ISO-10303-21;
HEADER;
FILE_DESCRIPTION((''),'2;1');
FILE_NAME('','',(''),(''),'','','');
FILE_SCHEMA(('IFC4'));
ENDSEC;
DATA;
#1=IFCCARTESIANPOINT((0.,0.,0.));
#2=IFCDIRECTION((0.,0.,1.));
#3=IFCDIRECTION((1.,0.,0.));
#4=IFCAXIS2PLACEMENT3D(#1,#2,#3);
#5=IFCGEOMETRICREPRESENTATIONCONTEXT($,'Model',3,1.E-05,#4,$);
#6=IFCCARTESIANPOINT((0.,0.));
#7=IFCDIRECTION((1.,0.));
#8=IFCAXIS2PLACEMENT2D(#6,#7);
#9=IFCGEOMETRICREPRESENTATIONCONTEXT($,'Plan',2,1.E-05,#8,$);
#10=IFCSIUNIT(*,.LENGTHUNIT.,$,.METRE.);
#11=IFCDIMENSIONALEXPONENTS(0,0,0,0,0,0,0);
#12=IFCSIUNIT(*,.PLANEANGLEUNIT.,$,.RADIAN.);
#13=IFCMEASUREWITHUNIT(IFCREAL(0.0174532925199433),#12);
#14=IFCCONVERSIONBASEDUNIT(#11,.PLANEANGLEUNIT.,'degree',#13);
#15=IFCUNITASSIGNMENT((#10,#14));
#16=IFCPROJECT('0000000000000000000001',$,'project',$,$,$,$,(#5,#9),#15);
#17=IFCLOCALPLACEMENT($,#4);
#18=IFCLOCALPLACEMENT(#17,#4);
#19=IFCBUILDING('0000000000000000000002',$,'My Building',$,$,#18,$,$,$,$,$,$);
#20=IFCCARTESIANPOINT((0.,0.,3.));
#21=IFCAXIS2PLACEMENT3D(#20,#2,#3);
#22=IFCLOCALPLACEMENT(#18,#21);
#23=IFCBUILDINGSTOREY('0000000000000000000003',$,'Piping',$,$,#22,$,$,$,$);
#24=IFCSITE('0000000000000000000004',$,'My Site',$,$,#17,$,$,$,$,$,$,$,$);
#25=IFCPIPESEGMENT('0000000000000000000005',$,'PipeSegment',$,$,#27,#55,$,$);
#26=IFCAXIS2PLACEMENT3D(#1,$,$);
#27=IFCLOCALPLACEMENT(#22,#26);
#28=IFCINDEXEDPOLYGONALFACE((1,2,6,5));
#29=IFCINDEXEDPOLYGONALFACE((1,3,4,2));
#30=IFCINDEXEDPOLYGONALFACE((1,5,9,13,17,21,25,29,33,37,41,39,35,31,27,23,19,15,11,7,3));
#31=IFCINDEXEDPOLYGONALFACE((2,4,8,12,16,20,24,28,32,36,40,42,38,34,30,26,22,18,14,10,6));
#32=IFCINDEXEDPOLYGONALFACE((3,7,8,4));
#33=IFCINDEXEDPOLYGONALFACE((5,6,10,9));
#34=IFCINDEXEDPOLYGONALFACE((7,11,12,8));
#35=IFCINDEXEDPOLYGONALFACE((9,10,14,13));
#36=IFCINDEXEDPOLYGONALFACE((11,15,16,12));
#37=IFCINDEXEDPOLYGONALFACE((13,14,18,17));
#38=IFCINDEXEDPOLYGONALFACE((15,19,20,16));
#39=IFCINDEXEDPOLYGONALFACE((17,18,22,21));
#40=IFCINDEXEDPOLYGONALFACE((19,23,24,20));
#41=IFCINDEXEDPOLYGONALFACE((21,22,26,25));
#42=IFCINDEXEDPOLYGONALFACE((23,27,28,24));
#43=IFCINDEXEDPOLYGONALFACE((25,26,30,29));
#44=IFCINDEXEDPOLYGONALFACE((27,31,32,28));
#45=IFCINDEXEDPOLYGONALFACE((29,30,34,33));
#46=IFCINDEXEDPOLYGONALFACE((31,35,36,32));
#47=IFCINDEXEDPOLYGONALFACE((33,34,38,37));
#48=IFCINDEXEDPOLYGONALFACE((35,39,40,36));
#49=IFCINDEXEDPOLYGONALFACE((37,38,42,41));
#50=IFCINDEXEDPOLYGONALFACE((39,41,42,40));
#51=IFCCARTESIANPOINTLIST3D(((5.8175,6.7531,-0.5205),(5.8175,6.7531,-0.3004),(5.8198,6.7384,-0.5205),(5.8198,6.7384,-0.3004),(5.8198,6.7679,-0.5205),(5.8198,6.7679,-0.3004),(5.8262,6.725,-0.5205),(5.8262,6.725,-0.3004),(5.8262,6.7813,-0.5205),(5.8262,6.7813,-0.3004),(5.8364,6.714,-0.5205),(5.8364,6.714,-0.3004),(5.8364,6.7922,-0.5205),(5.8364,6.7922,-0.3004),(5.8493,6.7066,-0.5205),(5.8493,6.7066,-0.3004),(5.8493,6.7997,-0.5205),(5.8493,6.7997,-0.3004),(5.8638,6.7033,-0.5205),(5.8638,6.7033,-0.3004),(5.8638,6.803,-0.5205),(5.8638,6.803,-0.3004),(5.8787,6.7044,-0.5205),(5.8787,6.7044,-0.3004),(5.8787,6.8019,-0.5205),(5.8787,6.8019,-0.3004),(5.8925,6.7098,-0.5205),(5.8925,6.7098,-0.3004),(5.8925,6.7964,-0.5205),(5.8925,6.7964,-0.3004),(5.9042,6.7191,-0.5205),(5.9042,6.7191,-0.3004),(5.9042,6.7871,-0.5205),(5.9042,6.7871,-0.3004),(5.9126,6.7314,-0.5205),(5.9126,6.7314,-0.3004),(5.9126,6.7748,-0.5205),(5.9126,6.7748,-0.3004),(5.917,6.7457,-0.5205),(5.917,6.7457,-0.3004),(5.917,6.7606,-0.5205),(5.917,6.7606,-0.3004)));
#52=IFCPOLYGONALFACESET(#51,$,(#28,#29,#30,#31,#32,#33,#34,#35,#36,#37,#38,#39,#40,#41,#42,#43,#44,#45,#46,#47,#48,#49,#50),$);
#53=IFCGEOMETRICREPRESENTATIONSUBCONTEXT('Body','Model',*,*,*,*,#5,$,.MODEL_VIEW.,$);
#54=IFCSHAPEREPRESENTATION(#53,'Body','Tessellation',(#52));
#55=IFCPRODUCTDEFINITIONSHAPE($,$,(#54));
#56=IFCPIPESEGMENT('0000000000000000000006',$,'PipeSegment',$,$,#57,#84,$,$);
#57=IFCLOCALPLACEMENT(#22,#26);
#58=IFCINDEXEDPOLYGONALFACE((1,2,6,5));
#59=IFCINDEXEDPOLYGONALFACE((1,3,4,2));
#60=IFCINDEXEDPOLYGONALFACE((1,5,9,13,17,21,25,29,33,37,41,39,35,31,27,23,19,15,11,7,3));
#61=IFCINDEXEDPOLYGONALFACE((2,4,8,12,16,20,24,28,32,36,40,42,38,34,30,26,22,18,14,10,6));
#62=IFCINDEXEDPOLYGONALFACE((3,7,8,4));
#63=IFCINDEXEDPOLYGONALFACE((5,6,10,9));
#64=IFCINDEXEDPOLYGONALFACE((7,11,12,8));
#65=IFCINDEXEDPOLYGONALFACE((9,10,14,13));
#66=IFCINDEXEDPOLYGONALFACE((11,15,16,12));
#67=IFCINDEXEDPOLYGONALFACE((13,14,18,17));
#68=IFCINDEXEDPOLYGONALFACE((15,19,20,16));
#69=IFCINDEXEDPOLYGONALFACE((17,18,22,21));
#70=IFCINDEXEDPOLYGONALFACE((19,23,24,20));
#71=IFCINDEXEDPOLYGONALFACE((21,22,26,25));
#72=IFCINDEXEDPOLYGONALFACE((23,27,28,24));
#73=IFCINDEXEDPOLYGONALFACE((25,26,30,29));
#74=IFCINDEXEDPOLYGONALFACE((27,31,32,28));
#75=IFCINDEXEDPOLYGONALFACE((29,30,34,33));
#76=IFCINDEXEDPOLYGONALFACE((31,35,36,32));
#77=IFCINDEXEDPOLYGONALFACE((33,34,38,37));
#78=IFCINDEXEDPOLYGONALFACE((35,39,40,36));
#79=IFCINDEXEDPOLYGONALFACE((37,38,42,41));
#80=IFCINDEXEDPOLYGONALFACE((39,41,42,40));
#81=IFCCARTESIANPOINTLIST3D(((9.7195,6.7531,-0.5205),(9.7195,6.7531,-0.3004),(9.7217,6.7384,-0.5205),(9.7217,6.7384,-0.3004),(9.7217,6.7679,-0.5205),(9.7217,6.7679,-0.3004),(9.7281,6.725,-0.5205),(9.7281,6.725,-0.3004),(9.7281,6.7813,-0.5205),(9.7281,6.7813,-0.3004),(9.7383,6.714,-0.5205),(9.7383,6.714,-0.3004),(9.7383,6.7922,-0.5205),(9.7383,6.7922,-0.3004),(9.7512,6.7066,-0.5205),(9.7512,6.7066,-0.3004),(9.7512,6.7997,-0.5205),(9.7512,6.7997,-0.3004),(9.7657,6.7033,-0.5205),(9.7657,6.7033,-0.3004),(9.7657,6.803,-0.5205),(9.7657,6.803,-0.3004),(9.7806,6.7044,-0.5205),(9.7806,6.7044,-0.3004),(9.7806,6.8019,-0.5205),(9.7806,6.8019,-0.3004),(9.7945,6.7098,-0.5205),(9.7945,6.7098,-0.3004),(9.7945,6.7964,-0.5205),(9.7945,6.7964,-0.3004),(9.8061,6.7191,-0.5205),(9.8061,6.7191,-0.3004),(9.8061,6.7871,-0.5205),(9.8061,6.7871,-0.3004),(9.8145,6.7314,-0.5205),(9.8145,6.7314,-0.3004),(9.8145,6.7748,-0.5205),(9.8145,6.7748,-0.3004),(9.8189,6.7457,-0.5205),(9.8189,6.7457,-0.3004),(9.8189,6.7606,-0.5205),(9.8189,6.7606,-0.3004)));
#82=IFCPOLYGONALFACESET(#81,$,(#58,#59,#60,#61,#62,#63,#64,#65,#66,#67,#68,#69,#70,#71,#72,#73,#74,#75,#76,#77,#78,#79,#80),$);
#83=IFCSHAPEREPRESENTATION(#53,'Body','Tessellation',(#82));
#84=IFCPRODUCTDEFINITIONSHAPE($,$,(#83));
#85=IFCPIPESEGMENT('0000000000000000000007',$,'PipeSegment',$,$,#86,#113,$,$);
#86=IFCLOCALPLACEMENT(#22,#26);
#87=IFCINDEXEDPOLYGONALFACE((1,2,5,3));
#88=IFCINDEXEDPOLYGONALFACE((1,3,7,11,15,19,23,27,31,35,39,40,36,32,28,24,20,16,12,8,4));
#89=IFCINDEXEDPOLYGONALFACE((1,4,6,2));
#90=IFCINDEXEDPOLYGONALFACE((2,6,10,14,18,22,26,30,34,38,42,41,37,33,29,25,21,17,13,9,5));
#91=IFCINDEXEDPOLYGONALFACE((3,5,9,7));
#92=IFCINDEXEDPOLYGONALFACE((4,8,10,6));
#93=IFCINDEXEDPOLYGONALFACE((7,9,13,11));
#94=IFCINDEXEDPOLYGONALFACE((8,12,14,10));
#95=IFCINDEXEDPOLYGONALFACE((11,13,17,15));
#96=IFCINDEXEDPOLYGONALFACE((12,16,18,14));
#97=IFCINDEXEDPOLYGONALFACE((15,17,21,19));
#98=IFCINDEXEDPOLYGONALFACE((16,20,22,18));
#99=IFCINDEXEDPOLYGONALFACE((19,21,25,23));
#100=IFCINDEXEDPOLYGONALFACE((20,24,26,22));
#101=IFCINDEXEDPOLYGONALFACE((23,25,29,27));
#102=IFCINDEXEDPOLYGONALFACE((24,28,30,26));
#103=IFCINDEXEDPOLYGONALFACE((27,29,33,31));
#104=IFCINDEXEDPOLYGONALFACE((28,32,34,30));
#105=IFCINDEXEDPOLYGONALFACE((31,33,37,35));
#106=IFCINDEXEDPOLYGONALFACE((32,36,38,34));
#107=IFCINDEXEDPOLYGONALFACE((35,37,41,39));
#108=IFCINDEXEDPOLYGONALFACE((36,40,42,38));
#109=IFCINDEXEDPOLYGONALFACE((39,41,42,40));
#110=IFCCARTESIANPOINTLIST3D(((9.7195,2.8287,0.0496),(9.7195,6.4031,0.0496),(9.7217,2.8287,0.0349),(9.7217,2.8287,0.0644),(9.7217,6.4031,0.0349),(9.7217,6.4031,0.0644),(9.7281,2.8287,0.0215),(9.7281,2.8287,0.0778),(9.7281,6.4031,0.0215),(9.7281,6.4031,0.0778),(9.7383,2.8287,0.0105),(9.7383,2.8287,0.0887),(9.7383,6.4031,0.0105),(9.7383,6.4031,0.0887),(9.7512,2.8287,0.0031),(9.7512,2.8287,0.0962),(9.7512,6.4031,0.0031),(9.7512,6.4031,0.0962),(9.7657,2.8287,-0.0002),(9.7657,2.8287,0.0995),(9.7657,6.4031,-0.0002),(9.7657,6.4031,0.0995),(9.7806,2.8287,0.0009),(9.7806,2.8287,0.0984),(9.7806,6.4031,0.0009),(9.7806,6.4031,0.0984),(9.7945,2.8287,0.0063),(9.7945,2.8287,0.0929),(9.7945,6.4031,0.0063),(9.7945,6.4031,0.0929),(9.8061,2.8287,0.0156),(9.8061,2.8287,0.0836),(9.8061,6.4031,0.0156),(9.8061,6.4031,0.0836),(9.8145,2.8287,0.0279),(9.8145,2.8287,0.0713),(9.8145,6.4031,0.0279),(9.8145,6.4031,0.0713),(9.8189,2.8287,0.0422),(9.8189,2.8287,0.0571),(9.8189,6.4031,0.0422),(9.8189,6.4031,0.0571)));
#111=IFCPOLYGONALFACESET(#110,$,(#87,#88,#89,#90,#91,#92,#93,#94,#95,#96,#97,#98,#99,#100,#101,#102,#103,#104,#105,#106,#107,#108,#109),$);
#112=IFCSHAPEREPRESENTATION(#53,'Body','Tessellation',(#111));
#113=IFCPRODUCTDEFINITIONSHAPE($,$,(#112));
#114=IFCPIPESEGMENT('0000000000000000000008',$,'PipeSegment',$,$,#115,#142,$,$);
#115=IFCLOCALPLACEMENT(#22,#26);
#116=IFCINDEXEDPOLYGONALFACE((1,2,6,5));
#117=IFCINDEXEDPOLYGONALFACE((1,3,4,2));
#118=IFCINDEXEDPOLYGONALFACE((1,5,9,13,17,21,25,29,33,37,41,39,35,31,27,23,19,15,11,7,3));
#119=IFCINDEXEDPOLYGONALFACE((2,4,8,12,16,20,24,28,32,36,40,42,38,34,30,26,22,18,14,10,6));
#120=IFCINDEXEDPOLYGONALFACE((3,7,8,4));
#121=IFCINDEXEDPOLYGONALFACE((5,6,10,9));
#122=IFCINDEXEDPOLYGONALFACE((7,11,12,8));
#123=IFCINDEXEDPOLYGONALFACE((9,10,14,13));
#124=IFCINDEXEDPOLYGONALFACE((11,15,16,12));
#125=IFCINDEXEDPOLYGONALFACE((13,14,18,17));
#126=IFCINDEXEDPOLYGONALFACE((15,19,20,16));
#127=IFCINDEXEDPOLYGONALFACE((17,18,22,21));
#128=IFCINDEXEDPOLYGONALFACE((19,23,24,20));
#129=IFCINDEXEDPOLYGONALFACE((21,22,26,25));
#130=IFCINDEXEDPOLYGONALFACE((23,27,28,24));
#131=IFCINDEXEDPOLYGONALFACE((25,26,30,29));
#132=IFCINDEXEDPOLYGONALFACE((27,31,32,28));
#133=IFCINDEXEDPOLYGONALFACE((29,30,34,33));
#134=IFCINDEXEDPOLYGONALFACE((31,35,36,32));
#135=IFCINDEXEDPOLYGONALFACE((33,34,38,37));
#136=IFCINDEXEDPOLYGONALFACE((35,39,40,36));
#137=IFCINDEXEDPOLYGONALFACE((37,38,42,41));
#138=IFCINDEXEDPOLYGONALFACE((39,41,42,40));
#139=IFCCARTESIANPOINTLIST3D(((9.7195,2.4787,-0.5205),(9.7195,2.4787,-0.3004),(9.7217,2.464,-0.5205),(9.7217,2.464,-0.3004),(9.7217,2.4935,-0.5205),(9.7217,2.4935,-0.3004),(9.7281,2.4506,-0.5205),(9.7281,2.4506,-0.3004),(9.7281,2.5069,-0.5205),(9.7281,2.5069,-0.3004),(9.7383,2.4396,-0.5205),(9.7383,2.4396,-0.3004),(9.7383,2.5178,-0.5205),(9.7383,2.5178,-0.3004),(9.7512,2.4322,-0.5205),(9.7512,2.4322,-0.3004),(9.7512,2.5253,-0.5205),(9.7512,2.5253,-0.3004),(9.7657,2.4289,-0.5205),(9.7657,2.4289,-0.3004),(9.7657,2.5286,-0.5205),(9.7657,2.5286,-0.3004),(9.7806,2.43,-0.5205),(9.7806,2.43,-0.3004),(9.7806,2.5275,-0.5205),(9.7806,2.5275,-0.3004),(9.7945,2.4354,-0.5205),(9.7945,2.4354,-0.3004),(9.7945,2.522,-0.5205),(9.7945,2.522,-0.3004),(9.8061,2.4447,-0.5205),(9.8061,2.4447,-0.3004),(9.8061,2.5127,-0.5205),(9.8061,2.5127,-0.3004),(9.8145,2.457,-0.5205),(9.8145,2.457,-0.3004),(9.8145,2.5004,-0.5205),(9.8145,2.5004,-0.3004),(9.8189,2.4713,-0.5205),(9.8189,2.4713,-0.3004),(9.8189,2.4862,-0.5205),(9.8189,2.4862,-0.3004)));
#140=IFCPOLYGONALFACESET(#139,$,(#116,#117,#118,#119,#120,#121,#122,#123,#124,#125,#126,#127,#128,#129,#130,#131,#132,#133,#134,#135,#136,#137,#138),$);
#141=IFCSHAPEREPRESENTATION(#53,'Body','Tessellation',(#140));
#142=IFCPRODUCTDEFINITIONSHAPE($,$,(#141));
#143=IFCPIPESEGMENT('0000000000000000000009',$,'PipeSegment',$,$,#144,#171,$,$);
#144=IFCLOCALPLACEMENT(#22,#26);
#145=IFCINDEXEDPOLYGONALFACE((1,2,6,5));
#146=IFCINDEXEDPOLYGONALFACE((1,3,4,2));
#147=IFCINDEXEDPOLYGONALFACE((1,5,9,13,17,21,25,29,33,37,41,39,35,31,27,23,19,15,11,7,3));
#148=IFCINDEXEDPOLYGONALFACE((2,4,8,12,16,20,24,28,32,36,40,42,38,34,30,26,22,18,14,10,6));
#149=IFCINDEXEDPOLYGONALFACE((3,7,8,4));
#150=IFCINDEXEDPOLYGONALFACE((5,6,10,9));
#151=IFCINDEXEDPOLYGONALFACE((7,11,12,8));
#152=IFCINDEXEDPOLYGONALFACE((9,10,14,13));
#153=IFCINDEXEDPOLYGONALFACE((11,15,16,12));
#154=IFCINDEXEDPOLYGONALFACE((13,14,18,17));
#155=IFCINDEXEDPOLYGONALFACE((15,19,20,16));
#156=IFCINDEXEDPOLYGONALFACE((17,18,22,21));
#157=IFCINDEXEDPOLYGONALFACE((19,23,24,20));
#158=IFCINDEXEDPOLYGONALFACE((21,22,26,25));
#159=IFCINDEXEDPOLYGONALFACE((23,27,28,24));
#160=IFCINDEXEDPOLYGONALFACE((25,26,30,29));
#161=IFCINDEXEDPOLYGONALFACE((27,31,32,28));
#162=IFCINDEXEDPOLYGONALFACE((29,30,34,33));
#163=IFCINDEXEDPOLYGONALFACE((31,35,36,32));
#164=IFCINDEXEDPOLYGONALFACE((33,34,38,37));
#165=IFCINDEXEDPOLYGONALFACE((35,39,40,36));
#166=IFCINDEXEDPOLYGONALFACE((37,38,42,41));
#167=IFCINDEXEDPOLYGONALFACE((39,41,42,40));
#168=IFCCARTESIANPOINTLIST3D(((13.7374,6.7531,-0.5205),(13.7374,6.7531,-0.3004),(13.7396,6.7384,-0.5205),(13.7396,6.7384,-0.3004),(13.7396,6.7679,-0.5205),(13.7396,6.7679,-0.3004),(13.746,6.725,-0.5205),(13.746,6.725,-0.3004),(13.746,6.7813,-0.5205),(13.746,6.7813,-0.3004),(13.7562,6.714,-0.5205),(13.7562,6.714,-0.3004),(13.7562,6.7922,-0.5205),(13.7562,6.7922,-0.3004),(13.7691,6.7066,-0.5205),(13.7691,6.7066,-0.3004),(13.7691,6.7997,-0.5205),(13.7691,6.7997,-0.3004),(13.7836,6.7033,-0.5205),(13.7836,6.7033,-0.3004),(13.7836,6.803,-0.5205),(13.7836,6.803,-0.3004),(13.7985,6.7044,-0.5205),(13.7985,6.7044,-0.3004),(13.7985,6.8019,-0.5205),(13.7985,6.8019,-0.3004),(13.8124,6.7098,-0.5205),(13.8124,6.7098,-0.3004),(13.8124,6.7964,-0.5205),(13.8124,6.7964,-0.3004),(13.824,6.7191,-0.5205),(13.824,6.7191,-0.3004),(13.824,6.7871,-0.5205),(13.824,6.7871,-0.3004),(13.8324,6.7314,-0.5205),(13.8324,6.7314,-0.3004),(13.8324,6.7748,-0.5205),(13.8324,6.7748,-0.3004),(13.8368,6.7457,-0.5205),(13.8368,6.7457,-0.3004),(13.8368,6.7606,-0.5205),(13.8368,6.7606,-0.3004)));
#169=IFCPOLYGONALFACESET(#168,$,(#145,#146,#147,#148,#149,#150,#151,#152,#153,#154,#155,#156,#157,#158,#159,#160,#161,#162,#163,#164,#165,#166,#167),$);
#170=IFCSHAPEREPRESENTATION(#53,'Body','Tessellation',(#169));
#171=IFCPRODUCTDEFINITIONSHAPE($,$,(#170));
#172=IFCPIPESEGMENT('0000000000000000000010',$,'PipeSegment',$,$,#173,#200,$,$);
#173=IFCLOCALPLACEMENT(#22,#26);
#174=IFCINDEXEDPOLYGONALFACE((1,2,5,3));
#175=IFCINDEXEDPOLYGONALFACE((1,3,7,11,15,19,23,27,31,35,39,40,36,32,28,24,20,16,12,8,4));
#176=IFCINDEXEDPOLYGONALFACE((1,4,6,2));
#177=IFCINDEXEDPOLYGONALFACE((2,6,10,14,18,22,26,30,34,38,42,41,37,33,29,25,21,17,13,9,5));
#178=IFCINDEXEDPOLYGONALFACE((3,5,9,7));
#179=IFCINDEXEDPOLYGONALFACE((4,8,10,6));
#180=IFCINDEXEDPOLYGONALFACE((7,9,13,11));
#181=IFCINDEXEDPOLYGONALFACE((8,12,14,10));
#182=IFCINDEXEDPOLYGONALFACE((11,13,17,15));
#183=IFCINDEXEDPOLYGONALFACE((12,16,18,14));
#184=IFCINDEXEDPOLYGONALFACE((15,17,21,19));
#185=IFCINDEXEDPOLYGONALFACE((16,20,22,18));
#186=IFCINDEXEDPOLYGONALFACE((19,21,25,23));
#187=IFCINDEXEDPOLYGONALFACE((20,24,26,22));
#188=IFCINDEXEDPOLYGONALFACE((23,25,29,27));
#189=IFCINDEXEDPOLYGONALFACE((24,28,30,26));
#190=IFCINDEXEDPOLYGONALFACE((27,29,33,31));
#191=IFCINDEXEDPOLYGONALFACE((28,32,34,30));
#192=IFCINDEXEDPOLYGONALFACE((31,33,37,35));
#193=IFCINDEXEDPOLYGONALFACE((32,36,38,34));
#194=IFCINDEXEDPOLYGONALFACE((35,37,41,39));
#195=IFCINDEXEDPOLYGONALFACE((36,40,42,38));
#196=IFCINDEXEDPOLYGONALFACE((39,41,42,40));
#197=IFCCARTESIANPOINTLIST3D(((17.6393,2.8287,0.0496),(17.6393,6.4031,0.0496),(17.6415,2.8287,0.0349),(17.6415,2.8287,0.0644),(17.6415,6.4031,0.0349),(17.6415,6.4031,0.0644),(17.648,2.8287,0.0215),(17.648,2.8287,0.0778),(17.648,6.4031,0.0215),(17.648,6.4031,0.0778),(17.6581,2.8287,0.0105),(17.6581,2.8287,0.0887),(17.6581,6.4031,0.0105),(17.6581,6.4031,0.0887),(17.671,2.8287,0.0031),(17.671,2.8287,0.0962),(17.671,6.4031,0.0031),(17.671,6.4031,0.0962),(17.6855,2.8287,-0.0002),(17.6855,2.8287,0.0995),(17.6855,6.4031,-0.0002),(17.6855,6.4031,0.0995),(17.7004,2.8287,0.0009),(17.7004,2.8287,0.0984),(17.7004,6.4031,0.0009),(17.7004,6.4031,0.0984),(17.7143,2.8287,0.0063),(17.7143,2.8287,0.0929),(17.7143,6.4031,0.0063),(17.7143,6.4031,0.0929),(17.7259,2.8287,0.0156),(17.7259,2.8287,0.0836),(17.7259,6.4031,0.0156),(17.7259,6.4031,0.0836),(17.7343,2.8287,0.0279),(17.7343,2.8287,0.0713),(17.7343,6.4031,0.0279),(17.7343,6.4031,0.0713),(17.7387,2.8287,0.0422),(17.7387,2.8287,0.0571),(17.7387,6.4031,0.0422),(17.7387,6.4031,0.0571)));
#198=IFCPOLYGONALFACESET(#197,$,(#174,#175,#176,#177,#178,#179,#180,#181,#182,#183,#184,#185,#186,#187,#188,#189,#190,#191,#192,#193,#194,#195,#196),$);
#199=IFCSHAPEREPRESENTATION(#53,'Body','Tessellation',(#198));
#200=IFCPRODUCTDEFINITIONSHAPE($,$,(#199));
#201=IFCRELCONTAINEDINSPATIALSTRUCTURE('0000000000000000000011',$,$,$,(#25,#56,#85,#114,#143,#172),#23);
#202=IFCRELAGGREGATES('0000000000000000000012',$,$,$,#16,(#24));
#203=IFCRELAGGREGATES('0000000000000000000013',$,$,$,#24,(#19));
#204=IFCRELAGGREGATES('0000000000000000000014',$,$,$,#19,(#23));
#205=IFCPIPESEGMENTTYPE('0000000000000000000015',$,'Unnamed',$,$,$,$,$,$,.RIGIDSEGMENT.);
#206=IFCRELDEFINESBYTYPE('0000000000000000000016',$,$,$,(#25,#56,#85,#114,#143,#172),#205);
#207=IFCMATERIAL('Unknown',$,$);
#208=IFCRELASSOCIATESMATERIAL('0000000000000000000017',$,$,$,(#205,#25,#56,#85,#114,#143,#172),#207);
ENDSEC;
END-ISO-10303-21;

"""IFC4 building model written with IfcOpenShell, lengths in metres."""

from ifc_helpers import new_model, entity, si_unit, converted_unit, frame, origin_with_axes, origin_2d_with_axis, place, context, subcontext, project, spatial, circle, extrude, material, material_profile, profile_set, profile_usage, type_object, element, save


model = new_model("IFC4")

# Units and contexts
model_context = context("Model", 3, precision=1e-05, world=origin_with_axes())
plan_context = context("Plan", 2, precision=1e-05, world=origin_2d_with_axis())
body_context = subcontext(model_context, "Body", "Model", "MODEL_VIEW")
ifc_project = project(units=[si_unit("LENGTHUNIT", "METRE"), converted_unit("PLANEANGLEUNIT", "degree", entity("IfcReal", 0.0174532925199433), si_unit("PLANEANGLEUNIT", "RADIAN"), dimensions=[0, 0, 0, 0, 0, 0, 0])], contexts=[model_context, plan_context])

# Site, building, storey
site_placement = place(None, origin_with_axes())
site = spatial("IfcSite", under=ifc_project, at=site_placement, Name="My Site")
building_placement = place(site_placement, origin_with_axes())
building = spatial("IfcBuilding", under=site, at=building_placement, Name="My Building")
storey_placement = place(building_placement, frame((0.0, 0.0, 3.0), z_axis=(0.0, 0.0, 1.0), x_axis=(1.0, 0.0, 0.0)))
storey = spatial("IfcBuildingStorey", under=building, at=storey_placement, Name="Piping")

# Pipe segments
ifc_material = material(Name="Unknown")
ifc_material_profile = material_profile(ifc_material, circle(Radius=0.05))
ifc_profile_set = profile_set([ifc_material_profile])
pipe_segment_type = type_object("IfcPipeSegmentType", Name="Unnamed", PredefinedType="RIGIDSEGMENT", material=ifc_profile_set)
ifc_profile_usage_1 = profile_usage(ifc_profile_set, cardinal=5)
pipe_segment_1_placement = place(storey_placement, frame((5.8675, 6.7531, -0.3004), z_axis=(0.0, 0.0, -1.0), x_axis=(-1.0, 0.0, 0.0)))
element("IfcPipeSegment", 1, at=pipe_segment_1_placement, inside=storey, type_object=pipe_segment_type, material=ifc_profile_usage_1, Name="PipeSegment", context=body_context, shape_type="SweptSolid", body=[
    extrude(circle(Radius=0.05), origin_with_axes(), (0.0, 0.0, 1.0), 0.2201),
])
ifc_profile_usage_2 = profile_usage(ifc_profile_set, cardinal=5)
pipe_segment_2_placement = place(storey_placement, frame((9.7695, 6.7531, -0.3004), z_axis=(0.0, 0.0, -1.0), x_axis=(-1.0, 0.0, 0.0)))
element("IfcPipeSegment", 2, at=pipe_segment_2_placement, inside=storey, type_object=pipe_segment_type, material=ifc_profile_usage_2, Name="PipeSegment", context=body_context, shape_type="SweptSolid", body=[
    extrude(circle(Radius=0.05), origin_with_axes(), (0.0, 0.0, 1.0), 0.2201),
])
ifc_profile_usage_3 = profile_usage(ifc_profile_set, cardinal=5)
pipe_segment_3_placement = place(storey_placement, frame((9.7695, 2.8287, 0.0496), z_axis=(0.0, 1.0, 0.0), x_axis=(-1.0, 0.0, 0.0)))
element("IfcPipeSegment", 3, at=pipe_segment_3_placement, inside=storey, type_object=pipe_segment_type, material=ifc_profile_usage_3, Name="PipeSegment", context=body_context, shape_type="SweptSolid", body=[
    extrude(circle(Radius=0.05), origin_with_axes(), (0.0, 0.0, 1.0), 3.5744),
])
ifc_profile_usage_4 = profile_usage(ifc_profile_set, cardinal=5)
pipe_segment_4_placement = place(storey_placement, frame((9.7695, 2.4787, -0.3004), z_axis=(0.0, 0.0, -1.0), x_axis=(-1.0, 0.0, 0.0)))
element("IfcPipeSegment", 4, at=pipe_segment_4_placement, inside=storey, type_object=pipe_segment_type, material=ifc_profile_usage_4, Name="PipeSegment", context=body_context, shape_type="SweptSolid", body=[
    extrude(circle(Radius=0.05), origin_with_axes(), (0.0, 0.0, 1.0), 0.2201),
])
ifc_profile_usage_5 = profile_usage(ifc_profile_set, cardinal=5)
pipe_segment_5_placement = place(storey_placement, frame((13.7874, 6.7531, -0.3004), z_axis=(0.0, 0.0, -1.0), x_axis=(-1.0, 0.0, 0.0)))
element("IfcPipeSegment", 5, at=pipe_segment_5_placement, inside=storey, type_object=pipe_segment_type, material=ifc_profile_usage_5, Name="PipeSegment", context=body_context, shape_type="SweptSolid", body=[
    extrude(circle(Radius=0.05), origin_with_axes(), (0.0, 0.0, 1.0), 0.2201),
])
ifc_profile_usage_6 = profile_usage(ifc_profile_set, cardinal=5)
pipe_segment_6_placement = place(storey_placement, frame((17.6893, 2.8287, 0.0496), z_axis=(0.0, 1.0, 0.0), x_axis=(-1.0, 0.0, 0.0)))
element("IfcPipeSegment", 6, at=pipe_segment_6_placement, inside=storey, type_object=pipe_segment_type, material=ifc_profile_usage_6, Name="PipeSegment", context=body_context, shape_type="SweptSolid", body=[
    extrude(circle(Radius=0.05), origin_with_axes(), (0.0, 0.0, 1.0), 3.5744),
])

save(model, "model.ifc")
